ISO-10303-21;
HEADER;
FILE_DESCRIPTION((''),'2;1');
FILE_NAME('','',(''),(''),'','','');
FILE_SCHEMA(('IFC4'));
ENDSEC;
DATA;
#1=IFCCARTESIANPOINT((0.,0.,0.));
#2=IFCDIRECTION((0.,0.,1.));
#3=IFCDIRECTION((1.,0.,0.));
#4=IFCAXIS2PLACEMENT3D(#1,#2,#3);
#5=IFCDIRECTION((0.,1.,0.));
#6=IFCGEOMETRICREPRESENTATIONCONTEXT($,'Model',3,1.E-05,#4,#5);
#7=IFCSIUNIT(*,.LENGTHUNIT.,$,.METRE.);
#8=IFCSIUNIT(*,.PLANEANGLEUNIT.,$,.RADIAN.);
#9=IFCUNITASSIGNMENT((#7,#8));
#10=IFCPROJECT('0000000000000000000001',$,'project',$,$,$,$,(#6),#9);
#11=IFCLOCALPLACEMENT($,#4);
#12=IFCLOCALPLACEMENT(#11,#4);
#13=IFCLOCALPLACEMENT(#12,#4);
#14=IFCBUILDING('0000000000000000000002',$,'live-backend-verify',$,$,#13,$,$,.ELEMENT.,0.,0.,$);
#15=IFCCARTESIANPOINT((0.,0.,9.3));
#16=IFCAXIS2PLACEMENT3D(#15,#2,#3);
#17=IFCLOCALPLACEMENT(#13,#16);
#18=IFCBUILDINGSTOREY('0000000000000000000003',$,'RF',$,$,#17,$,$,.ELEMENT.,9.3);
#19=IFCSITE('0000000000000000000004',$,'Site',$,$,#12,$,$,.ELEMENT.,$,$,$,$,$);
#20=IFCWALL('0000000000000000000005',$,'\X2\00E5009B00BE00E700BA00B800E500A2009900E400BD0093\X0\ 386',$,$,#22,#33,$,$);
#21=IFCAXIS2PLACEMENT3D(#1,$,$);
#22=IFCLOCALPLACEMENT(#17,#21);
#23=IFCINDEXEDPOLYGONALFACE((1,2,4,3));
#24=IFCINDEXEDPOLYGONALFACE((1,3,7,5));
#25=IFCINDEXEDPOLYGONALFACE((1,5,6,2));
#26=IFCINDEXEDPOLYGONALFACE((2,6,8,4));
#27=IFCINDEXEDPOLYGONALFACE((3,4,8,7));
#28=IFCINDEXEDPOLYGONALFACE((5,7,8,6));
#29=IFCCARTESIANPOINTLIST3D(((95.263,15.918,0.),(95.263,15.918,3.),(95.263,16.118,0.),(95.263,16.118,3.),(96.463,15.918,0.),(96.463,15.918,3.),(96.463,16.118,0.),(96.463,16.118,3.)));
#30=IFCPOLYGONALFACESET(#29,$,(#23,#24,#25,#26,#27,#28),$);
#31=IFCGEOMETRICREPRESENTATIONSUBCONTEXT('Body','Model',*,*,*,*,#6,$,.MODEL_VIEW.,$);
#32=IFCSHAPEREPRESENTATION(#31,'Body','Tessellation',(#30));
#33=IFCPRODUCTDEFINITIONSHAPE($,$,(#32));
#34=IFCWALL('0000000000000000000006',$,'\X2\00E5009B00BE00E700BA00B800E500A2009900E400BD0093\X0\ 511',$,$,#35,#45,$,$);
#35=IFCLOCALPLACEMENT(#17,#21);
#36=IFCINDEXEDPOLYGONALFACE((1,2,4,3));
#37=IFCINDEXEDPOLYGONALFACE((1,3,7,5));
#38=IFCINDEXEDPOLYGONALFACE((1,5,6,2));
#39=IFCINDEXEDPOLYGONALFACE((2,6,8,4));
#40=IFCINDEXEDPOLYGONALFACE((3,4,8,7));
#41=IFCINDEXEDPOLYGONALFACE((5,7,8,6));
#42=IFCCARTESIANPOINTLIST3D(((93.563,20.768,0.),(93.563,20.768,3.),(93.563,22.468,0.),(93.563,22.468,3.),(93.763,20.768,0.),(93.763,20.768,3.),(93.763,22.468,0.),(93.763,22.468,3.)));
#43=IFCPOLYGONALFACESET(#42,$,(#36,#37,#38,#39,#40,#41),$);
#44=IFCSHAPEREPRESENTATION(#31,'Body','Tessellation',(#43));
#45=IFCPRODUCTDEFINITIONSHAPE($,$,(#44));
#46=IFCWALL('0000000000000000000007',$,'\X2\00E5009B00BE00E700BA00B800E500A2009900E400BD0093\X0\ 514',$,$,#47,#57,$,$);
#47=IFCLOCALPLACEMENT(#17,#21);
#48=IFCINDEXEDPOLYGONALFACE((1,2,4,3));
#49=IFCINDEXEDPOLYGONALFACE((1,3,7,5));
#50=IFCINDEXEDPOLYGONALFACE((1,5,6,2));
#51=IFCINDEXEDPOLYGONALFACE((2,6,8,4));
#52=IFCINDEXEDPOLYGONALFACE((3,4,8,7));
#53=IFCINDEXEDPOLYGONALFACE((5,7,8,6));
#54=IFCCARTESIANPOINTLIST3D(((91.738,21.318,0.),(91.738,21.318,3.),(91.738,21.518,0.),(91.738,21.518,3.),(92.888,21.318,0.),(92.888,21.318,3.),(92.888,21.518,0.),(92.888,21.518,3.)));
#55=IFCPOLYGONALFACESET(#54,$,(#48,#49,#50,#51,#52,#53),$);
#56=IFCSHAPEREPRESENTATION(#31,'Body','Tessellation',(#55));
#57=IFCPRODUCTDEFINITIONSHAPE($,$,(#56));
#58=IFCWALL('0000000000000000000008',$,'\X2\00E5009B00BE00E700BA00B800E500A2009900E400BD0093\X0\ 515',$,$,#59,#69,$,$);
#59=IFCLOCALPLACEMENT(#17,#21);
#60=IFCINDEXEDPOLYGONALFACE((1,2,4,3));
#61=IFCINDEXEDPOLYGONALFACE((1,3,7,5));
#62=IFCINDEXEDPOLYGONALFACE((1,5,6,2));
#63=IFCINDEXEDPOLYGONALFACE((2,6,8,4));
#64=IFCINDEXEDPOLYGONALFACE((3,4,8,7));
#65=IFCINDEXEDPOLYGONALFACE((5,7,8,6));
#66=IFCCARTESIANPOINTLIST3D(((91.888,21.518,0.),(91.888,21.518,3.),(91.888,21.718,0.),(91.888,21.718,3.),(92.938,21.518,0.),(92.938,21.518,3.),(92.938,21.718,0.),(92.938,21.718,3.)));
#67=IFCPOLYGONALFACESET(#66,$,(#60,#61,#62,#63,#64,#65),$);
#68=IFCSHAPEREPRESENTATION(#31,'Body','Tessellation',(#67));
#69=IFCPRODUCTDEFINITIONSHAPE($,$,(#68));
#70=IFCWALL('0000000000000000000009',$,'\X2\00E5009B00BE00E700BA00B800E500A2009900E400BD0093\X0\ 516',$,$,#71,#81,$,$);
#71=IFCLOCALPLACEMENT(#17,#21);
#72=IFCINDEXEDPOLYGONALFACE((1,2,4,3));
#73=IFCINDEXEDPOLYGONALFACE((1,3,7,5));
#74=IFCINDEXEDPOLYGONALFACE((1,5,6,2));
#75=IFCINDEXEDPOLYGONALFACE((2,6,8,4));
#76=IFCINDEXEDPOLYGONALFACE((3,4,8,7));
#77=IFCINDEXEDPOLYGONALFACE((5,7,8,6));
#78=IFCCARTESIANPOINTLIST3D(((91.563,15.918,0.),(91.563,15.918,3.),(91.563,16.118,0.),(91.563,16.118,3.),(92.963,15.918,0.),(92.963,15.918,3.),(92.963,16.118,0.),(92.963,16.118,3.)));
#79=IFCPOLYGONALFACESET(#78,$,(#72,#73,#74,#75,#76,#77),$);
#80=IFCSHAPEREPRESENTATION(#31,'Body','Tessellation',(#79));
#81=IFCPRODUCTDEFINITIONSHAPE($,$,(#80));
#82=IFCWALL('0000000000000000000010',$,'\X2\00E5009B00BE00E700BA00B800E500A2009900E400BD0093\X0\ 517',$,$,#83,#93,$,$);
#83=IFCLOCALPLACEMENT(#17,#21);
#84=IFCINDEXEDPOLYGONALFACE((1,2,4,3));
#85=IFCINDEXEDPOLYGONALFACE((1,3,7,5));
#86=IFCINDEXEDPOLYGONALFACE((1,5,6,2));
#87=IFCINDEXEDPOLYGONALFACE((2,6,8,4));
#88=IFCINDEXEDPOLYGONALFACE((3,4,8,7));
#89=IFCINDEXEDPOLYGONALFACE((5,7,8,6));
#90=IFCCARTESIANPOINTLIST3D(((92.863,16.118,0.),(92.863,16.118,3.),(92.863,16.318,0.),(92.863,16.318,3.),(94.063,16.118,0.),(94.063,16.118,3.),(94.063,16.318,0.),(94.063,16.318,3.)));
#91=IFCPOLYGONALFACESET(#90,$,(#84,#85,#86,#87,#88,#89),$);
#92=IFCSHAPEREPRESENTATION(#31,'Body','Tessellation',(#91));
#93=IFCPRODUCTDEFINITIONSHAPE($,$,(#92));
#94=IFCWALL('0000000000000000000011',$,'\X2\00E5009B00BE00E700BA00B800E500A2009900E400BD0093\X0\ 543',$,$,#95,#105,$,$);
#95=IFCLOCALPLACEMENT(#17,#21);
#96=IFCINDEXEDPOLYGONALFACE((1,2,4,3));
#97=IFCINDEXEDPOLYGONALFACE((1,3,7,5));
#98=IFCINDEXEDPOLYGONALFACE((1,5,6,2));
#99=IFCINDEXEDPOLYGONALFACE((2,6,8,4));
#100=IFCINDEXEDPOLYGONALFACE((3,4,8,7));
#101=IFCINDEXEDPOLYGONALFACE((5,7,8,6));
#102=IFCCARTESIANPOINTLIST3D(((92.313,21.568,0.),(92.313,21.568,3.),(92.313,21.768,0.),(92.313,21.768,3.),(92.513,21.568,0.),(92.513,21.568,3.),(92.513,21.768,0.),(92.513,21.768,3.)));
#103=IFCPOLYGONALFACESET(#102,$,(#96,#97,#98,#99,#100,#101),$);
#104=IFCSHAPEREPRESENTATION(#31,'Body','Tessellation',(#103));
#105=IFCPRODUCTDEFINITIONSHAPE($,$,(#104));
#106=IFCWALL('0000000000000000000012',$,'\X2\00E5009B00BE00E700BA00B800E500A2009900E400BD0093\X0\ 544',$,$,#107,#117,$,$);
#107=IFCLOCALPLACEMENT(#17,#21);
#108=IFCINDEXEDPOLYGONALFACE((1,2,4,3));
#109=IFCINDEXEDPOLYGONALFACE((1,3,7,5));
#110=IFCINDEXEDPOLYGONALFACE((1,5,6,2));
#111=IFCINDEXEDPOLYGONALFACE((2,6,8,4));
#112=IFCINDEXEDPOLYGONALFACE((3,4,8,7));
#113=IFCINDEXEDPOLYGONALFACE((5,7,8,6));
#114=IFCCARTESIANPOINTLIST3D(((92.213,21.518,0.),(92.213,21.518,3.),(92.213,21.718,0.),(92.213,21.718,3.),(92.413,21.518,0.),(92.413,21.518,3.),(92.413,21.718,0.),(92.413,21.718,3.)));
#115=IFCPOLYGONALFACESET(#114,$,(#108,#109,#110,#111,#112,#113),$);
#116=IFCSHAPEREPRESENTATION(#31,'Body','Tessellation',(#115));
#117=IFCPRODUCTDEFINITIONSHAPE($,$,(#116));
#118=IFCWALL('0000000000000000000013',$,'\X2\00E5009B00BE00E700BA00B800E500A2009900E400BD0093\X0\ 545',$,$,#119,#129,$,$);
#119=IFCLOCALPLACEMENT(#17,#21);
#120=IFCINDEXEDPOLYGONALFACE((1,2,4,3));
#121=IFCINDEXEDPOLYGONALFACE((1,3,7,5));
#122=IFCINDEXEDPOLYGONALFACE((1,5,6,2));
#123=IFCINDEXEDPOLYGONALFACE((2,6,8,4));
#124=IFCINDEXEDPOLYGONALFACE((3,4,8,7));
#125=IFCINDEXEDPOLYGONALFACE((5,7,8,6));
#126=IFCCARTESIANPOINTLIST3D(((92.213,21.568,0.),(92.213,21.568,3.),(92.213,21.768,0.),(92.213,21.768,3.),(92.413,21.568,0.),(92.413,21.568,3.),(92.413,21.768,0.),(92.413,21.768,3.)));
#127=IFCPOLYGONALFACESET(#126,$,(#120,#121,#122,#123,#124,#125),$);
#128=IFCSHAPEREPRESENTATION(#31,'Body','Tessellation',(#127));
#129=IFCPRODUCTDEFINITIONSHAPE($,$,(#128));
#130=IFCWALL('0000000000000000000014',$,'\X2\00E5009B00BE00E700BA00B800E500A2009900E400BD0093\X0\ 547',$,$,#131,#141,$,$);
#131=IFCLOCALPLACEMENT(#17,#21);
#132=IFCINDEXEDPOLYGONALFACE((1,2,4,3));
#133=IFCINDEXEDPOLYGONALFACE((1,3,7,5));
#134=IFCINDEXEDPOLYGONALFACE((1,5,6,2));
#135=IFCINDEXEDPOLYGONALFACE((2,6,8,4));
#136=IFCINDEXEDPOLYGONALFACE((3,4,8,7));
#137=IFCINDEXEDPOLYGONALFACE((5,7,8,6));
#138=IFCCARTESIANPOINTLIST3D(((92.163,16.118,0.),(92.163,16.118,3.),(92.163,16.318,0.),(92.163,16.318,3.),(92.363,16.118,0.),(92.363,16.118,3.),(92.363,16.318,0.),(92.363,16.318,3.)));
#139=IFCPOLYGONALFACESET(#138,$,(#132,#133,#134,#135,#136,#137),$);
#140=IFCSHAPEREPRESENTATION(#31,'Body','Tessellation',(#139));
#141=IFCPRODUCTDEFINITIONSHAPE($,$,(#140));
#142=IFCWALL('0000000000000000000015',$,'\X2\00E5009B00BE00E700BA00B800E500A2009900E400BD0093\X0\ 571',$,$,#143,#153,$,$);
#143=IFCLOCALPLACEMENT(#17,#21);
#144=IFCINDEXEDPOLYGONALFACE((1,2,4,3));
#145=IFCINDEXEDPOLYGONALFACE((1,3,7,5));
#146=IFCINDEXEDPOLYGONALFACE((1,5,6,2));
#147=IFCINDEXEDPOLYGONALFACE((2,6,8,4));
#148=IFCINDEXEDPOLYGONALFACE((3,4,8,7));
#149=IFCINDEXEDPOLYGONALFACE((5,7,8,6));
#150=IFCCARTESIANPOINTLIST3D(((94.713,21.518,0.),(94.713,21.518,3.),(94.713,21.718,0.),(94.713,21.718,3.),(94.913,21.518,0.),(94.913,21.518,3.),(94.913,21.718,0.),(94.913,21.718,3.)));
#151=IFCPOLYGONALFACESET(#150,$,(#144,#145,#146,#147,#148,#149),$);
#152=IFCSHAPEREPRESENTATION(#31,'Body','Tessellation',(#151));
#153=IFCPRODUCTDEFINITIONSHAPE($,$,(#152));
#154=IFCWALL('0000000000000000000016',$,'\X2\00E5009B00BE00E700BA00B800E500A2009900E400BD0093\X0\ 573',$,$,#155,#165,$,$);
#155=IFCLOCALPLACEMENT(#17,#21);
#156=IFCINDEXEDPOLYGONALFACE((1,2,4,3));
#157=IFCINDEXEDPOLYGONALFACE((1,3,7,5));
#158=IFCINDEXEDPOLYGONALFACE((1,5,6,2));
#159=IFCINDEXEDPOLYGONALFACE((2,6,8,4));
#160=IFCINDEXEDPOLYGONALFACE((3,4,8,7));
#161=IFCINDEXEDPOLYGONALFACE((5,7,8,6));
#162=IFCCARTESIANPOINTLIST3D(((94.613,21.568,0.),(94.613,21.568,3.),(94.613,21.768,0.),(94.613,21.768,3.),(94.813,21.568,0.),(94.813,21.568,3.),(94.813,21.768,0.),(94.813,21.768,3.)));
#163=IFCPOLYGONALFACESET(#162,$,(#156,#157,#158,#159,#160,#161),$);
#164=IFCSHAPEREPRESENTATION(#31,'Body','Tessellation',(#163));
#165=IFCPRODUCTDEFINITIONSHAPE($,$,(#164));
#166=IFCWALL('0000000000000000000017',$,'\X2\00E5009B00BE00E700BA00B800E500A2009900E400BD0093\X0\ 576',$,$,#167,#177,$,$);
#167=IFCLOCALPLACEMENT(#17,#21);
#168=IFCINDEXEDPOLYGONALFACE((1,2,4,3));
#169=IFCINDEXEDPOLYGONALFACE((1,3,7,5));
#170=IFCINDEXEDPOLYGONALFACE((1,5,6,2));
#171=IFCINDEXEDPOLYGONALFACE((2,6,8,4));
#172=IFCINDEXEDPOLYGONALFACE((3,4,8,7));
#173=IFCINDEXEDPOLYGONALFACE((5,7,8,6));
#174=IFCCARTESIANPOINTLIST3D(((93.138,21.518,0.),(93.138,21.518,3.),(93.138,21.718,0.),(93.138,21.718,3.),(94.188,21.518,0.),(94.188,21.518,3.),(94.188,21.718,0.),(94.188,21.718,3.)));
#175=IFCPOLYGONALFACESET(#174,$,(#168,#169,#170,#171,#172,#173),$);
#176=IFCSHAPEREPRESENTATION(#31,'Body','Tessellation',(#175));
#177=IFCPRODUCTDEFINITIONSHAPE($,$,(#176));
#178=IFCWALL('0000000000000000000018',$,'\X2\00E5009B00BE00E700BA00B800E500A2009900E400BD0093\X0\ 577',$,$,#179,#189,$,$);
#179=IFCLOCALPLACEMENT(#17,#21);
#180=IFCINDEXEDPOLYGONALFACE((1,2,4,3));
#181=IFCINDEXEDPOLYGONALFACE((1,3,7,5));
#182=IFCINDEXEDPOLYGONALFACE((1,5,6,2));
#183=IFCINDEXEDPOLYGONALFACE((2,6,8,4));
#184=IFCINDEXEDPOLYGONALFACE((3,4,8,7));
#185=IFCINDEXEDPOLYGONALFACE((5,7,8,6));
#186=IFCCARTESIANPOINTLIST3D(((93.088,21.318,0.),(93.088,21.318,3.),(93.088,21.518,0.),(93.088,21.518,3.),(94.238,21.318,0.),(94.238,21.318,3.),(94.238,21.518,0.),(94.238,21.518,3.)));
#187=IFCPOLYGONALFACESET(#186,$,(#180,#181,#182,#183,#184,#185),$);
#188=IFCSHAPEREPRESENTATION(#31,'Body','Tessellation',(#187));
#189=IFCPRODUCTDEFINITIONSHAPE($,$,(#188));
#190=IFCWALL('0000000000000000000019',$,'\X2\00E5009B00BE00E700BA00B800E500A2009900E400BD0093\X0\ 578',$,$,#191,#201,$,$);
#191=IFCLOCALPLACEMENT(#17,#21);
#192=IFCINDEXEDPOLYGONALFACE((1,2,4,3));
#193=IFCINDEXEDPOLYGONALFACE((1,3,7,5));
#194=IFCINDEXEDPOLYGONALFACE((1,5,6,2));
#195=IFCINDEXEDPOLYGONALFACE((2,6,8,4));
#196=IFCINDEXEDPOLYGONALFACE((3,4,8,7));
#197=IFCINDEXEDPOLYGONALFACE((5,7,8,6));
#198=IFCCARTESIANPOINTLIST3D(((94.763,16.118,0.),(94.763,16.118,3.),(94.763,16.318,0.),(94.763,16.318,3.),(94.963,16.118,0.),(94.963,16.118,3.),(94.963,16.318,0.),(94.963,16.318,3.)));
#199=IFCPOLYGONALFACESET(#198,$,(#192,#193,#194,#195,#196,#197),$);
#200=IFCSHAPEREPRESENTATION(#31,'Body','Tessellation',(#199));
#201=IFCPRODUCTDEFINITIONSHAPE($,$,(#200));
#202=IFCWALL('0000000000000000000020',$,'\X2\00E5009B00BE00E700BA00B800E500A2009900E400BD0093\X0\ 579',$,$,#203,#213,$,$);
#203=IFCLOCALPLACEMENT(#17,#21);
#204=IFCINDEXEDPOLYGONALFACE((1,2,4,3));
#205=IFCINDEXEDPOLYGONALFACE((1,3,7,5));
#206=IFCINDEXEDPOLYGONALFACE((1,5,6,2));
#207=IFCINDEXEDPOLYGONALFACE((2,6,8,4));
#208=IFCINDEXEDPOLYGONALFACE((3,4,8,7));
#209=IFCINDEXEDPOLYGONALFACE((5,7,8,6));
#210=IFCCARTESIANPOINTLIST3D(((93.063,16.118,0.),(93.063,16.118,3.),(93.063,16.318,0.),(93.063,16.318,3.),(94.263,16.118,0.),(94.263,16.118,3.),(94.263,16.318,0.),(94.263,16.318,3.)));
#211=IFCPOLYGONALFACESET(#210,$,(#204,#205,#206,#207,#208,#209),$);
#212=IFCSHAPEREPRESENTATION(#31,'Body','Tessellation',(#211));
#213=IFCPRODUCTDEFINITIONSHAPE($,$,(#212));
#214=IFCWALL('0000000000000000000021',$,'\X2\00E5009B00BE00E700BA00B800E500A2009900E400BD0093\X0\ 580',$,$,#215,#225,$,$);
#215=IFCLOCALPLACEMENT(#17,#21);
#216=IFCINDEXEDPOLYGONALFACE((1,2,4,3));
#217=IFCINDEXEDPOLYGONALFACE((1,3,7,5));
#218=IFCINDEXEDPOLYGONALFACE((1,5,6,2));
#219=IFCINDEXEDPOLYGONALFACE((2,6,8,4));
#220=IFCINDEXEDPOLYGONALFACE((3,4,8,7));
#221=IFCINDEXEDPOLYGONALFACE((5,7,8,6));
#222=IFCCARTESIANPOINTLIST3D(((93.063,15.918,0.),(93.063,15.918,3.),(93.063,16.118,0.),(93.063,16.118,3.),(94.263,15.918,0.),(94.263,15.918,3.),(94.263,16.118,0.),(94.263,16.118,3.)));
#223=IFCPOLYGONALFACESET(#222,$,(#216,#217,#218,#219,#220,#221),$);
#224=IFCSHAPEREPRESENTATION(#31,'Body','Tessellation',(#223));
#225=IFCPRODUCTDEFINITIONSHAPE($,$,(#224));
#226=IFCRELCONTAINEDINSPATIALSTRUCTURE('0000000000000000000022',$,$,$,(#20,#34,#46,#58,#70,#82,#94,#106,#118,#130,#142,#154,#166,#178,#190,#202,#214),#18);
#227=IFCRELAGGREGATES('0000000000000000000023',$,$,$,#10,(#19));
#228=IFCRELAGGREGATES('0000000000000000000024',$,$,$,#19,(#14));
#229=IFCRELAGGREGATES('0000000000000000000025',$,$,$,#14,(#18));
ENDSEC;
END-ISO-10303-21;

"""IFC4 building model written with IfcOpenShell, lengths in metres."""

from ifc_helpers import new_model, si_unit, direction, frame, frame_2d, origin_with_axes, place, context, subcontext, project, spatial, rectangle, extrude, element, save


model = new_model("IFC4")

# Units and contexts
model_context = context("Model", 3, precision=1e-05, world=origin_with_axes(), true_north=direction((0.0, 1.0, 0.0)))
body_context = subcontext(model_context, "Body", "Model", "MODEL_VIEW")
ifc_project = project(units=[si_unit("LENGTHUNIT", "METRE"), si_unit("PLANEANGLEUNIT", "RADIAN")], contexts=[model_context])

# Site, building, storey
placement = place(None, origin_with_axes())
site_placement = place(placement, origin_with_axes())
site = spatial("IfcSite", under=ifc_project, at=site_placement, Name="Site", CompositionType="ELEMENT")
building_placement = place(site_placement, origin_with_axes())
building = spatial("IfcBuilding", under=site, at=building_placement, Name="live-backend-verify", CompositionType="ELEMENT", ElevationOfRefHeight=0.0, ElevationOfTerrain=0.0)
storey_placement = place(building_placement, frame((0.0, 0.0, 9.3), z_axis=(0.0, 0.0, 1.0), x_axis=(1.0, 0.0, 0.0)))
storey = spatial("IfcBuildingStorey", under=building, at=storey_placement, Name="RF", CompositionType="ELEMENT", Elevation=9.3)

# Walls
wall_1_placement = place(storey_placement, frame((95.863, 16.018, 0.0), z_axis=(0.0, 0.0, 1.0), x_axis=(1.0, 0.0, 0.0)))
element("IfcWall", 1, at=wall_1_placement, inside=storey, Name="å\u009b¾çº¸å¢\u0099ä½\u0093 386", context=body_context, shape_type="SweptSolid", body=[
    extrude(rectangle(XDim=1.2, YDim=0.2, at=frame_2d((0.0, 0.0), x_axis=(1.0, 0.0, 0.0))), frame((0.0, 0.0, 0.0), z_axis=(0.0, 0.0, 1.0)), (0.0, 0.0, 1.0), 3.0),
])
wall_2_placement = place(storey_placement, frame((93.663, 21.618, 0.0), z_axis=(0.0, 0.0, 1.0), x_axis=(0.0, 1.0, 0.0)))
element("IfcWall", 2, at=wall_2_placement, inside=storey, Name="å\u009b¾çº¸å¢\u0099ä½\u0093 511", context=body_context, shape_type="SweptSolid", body=[
    extrude(rectangle(XDim=1.7, YDim=0.2, at=frame_2d((0.0, 0.0), x_axis=(1.0, 0.0, 0.0))), frame((0.0, 0.0, 0.0), z_axis=(0.0, 0.0, 1.0)), (0.0, 0.0, 1.0), 3.0),
])
wall_3_placement = place(storey_placement, frame((92.313, 21.418, 0.0), z_axis=(0.0, 0.0, 1.0), x_axis=(1.0, 0.0, 0.0)))
element("IfcWall", 3, at=wall_3_placement, inside=storey, Name="å\u009b¾çº¸å¢\u0099ä½\u0093 514", context=body_context, shape_type="SweptSolid", body=[
    extrude(rectangle(XDim=1.15, YDim=0.2, at=frame_2d((0.0, 0.0), x_axis=(1.0, 0.0, 0.0))), frame((0.0, 0.0, 0.0), z_axis=(0.0, 0.0, 1.0)), (0.0, 0.0, 1.0), 3.0),
])
wall_4_placement = place(storey_placement, frame((92.413, 21.618, 0.0), z_axis=(0.0, 0.0, 1.0), x_axis=(1.0, 0.0, 0.0)))
element("IfcWall", 4, at=wall_4_placement, inside=storey, Name="å\u009b¾çº¸å¢\u0099ä½\u0093 515", context=body_context, shape_type="SweptSolid", body=[
    extrude(rectangle(XDim=1.05, YDim=0.2, at=frame_2d((0.0, 0.0), x_axis=(1.0, 0.0, 0.0))), frame((0.0, 0.0, 0.0), z_axis=(0.0, 0.0, 1.0)), (0.0, 0.0, 1.0), 3.0),
])
wall_5_placement = place(storey_placement, frame((92.263, 16.018, 0.0), z_axis=(0.0, 0.0, 1.0), x_axis=(1.0, 0.0, 0.0)))
element("IfcWall", 5, at=wall_5_placement, inside=storey, Name="å\u009b¾çº¸å¢\u0099ä½\u0093 516", context=body_context, shape_type="SweptSolid", body=[
    extrude(rectangle(XDim=1.4, YDim=0.2, at=frame_2d((0.0, 0.0), x_axis=(1.0, 0.0, 0.0))), frame((0.0, 0.0, 0.0), z_axis=(0.0, 0.0, 1.0)), (0.0, 0.0, 1.0), 3.0),
])
wall_6_placement = place(storey_placement, frame((93.463, 16.218, 0.0), z_axis=(0.0, 0.0, 1.0), x_axis=(-1.0, 0.0, 0.0)))
element("IfcWall", 6, at=wall_6_placement, inside=storey, Name="å\u009b¾çº¸å¢\u0099ä½\u0093 517", context=body_context, shape_type="SweptSolid", body=[
    extrude(rectangle(XDim=1.2, YDim=0.2, at=frame_2d((0.0, 0.0), x_axis=(1.0, 0.0, 0.0))), frame((0.0, 0.0, 0.0), z_axis=(0.0, 0.0, 1.0)), (0.0, 0.0, 1.0), 3.0),
])
for number, where, z_axis, x_axis, name in (
    (7, (92.413, 21.668, 0.0), (0.0, 0.0, 1.0), (-1.0, 0.0, 0.0), "å\u009b¾çº¸å¢\u0099ä½\u0093 543"),
    (8, (92.313, 21.618, 0.0), (0.0, 0.0, 1.0), (0.0, -1.0, 0.0), "å\u009b¾çº¸å¢\u0099ä½\u0093 544"),
    (9, (92.313, 21.668, 0.0), (0.0, 0.0, 1.0), (0.0, -1.0, 0.0), "å\u009b¾çº¸å¢\u0099ä½\u0093 545"),
    (10, (92.263, 16.218, 0.0), (0.0, 0.0, 1.0), (0.0, -1.0, 0.0), "å\u009b¾çº¸å¢\u0099ä½\u0093 547"),
    (11, (94.813, 21.618, 0.0), (0.0, 0.0, 1.0), (0.0, -1.0, 0.0), "å\u009b¾çº¸å¢\u0099ä½\u0093 571"),
    (12, (94.713, 21.668, 0.0), (0.0, 0.0, 1.0), (1.0, 0.0, 0.0), "å\u009b¾çº¸å¢\u0099ä½\u0093 573"),
):
    element("IfcWall", number, at=place(storey_placement, frame(where, z_axis=z_axis, x_axis=x_axis)), inside=storey, Name=name, context=body_context, shape_type="SweptSolid", body=[
        extrude(rectangle(XDim=0.2, YDim=0.2, at=frame_2d((0.0, 0.0), x_axis=(1.0, 0.0, 0.0))), frame((0.0, 0.0, 0.0), z_axis=(0.0, 0.0, 1.0)), (0.0, 0.0, 1.0), 3.0),
    ])
wall_7_placement = place(storey_placement, frame((93.663, 21.618, 0.0), z_axis=(0.0, 0.0, 1.0), x_axis=(1.0, 0.0, 0.0)))
element("IfcWall", 13, at=wall_7_placement, inside=storey, Name="å\u009b¾çº¸å¢\u0099ä½\u0093 576", context=body_context, shape_type="SweptSolid", body=[
    extrude(rectangle(XDim=1.05, YDim=0.2, at=frame_2d((0.0, 0.0), x_axis=(1.0, 0.0, 0.0))), frame((0.0, 0.0, 0.0), z_axis=(0.0, 0.0, 1.0)), (0.0, 0.0, 1.0), 3.0),
])
wall_8_placement = place(storey_placement, frame((93.663, 21.418, 0.0), z_axis=(0.0, 0.0, 1.0), x_axis=(1.0, 0.0, 0.0)))
element("IfcWall", 14, at=wall_8_placement, inside=storey, Name="å\u009b¾çº¸å¢\u0099ä½\u0093 577", context=body_context, shape_type="SweptSolid", body=[
    extrude(rectangle(XDim=1.15, YDim=0.2, at=frame_2d((0.0, 0.0), x_axis=(1.0, 0.0, 0.0))), frame((0.0, 0.0, 0.0), z_axis=(0.0, 0.0, 1.0)), (0.0, 0.0, 1.0), 3.0),
])
wall_9_placement = place(storey_placement, frame((94.863, 16.218, 0.0), z_axis=(0.0, 0.0, 1.0), x_axis=(0.0, -1.0, 0.0)))
element("IfcWall", 15, at=wall_9_placement, inside=storey, Name="å\u009b¾çº¸å¢\u0099ä½\u0093 578", context=body_context, shape_type="SweptSolid", body=[
    extrude(rectangle(XDim=0.2, YDim=0.2, at=frame_2d((0.0, 0.0), x_axis=(1.0, 0.0, 0.0))), frame((0.0, 0.0, 0.0), z_axis=(0.0, 0.0, 1.0)), (0.0, 0.0, 1.0), 3.0),
])
for number, where, z_axis, x_axis, name in (
    (16, (93.663, 16.218, 0.0), (0.0, 0.0, 1.0), (1.0, 0.0, 0.0), "å\u009b¾çº¸å¢\u0099ä½\u0093 579"),
    (17, (93.663, 16.018, 0.0), (0.0, 0.0, 1.0), (1.0, 0.0, 0.0), "å\u009b¾çº¸å¢\u0099ä½\u0093 580"),
):
    element("IfcWall", number, at=place(storey_placement, frame(where, z_axis=z_axis, x_axis=x_axis)), inside=storey, Name=name, context=body_context, shape_type="SweptSolid", body=[
        extrude(rectangle(XDim=1.2, YDim=0.2, at=frame_2d((0.0, 0.0), x_axis=(1.0, 0.0, 0.0))), frame((0.0, 0.0, 0.0), z_axis=(0.0, 0.0, 1.0)), (0.0, 0.0, 1.0), 3.0),
    ])

save(model, "model.ifc")
